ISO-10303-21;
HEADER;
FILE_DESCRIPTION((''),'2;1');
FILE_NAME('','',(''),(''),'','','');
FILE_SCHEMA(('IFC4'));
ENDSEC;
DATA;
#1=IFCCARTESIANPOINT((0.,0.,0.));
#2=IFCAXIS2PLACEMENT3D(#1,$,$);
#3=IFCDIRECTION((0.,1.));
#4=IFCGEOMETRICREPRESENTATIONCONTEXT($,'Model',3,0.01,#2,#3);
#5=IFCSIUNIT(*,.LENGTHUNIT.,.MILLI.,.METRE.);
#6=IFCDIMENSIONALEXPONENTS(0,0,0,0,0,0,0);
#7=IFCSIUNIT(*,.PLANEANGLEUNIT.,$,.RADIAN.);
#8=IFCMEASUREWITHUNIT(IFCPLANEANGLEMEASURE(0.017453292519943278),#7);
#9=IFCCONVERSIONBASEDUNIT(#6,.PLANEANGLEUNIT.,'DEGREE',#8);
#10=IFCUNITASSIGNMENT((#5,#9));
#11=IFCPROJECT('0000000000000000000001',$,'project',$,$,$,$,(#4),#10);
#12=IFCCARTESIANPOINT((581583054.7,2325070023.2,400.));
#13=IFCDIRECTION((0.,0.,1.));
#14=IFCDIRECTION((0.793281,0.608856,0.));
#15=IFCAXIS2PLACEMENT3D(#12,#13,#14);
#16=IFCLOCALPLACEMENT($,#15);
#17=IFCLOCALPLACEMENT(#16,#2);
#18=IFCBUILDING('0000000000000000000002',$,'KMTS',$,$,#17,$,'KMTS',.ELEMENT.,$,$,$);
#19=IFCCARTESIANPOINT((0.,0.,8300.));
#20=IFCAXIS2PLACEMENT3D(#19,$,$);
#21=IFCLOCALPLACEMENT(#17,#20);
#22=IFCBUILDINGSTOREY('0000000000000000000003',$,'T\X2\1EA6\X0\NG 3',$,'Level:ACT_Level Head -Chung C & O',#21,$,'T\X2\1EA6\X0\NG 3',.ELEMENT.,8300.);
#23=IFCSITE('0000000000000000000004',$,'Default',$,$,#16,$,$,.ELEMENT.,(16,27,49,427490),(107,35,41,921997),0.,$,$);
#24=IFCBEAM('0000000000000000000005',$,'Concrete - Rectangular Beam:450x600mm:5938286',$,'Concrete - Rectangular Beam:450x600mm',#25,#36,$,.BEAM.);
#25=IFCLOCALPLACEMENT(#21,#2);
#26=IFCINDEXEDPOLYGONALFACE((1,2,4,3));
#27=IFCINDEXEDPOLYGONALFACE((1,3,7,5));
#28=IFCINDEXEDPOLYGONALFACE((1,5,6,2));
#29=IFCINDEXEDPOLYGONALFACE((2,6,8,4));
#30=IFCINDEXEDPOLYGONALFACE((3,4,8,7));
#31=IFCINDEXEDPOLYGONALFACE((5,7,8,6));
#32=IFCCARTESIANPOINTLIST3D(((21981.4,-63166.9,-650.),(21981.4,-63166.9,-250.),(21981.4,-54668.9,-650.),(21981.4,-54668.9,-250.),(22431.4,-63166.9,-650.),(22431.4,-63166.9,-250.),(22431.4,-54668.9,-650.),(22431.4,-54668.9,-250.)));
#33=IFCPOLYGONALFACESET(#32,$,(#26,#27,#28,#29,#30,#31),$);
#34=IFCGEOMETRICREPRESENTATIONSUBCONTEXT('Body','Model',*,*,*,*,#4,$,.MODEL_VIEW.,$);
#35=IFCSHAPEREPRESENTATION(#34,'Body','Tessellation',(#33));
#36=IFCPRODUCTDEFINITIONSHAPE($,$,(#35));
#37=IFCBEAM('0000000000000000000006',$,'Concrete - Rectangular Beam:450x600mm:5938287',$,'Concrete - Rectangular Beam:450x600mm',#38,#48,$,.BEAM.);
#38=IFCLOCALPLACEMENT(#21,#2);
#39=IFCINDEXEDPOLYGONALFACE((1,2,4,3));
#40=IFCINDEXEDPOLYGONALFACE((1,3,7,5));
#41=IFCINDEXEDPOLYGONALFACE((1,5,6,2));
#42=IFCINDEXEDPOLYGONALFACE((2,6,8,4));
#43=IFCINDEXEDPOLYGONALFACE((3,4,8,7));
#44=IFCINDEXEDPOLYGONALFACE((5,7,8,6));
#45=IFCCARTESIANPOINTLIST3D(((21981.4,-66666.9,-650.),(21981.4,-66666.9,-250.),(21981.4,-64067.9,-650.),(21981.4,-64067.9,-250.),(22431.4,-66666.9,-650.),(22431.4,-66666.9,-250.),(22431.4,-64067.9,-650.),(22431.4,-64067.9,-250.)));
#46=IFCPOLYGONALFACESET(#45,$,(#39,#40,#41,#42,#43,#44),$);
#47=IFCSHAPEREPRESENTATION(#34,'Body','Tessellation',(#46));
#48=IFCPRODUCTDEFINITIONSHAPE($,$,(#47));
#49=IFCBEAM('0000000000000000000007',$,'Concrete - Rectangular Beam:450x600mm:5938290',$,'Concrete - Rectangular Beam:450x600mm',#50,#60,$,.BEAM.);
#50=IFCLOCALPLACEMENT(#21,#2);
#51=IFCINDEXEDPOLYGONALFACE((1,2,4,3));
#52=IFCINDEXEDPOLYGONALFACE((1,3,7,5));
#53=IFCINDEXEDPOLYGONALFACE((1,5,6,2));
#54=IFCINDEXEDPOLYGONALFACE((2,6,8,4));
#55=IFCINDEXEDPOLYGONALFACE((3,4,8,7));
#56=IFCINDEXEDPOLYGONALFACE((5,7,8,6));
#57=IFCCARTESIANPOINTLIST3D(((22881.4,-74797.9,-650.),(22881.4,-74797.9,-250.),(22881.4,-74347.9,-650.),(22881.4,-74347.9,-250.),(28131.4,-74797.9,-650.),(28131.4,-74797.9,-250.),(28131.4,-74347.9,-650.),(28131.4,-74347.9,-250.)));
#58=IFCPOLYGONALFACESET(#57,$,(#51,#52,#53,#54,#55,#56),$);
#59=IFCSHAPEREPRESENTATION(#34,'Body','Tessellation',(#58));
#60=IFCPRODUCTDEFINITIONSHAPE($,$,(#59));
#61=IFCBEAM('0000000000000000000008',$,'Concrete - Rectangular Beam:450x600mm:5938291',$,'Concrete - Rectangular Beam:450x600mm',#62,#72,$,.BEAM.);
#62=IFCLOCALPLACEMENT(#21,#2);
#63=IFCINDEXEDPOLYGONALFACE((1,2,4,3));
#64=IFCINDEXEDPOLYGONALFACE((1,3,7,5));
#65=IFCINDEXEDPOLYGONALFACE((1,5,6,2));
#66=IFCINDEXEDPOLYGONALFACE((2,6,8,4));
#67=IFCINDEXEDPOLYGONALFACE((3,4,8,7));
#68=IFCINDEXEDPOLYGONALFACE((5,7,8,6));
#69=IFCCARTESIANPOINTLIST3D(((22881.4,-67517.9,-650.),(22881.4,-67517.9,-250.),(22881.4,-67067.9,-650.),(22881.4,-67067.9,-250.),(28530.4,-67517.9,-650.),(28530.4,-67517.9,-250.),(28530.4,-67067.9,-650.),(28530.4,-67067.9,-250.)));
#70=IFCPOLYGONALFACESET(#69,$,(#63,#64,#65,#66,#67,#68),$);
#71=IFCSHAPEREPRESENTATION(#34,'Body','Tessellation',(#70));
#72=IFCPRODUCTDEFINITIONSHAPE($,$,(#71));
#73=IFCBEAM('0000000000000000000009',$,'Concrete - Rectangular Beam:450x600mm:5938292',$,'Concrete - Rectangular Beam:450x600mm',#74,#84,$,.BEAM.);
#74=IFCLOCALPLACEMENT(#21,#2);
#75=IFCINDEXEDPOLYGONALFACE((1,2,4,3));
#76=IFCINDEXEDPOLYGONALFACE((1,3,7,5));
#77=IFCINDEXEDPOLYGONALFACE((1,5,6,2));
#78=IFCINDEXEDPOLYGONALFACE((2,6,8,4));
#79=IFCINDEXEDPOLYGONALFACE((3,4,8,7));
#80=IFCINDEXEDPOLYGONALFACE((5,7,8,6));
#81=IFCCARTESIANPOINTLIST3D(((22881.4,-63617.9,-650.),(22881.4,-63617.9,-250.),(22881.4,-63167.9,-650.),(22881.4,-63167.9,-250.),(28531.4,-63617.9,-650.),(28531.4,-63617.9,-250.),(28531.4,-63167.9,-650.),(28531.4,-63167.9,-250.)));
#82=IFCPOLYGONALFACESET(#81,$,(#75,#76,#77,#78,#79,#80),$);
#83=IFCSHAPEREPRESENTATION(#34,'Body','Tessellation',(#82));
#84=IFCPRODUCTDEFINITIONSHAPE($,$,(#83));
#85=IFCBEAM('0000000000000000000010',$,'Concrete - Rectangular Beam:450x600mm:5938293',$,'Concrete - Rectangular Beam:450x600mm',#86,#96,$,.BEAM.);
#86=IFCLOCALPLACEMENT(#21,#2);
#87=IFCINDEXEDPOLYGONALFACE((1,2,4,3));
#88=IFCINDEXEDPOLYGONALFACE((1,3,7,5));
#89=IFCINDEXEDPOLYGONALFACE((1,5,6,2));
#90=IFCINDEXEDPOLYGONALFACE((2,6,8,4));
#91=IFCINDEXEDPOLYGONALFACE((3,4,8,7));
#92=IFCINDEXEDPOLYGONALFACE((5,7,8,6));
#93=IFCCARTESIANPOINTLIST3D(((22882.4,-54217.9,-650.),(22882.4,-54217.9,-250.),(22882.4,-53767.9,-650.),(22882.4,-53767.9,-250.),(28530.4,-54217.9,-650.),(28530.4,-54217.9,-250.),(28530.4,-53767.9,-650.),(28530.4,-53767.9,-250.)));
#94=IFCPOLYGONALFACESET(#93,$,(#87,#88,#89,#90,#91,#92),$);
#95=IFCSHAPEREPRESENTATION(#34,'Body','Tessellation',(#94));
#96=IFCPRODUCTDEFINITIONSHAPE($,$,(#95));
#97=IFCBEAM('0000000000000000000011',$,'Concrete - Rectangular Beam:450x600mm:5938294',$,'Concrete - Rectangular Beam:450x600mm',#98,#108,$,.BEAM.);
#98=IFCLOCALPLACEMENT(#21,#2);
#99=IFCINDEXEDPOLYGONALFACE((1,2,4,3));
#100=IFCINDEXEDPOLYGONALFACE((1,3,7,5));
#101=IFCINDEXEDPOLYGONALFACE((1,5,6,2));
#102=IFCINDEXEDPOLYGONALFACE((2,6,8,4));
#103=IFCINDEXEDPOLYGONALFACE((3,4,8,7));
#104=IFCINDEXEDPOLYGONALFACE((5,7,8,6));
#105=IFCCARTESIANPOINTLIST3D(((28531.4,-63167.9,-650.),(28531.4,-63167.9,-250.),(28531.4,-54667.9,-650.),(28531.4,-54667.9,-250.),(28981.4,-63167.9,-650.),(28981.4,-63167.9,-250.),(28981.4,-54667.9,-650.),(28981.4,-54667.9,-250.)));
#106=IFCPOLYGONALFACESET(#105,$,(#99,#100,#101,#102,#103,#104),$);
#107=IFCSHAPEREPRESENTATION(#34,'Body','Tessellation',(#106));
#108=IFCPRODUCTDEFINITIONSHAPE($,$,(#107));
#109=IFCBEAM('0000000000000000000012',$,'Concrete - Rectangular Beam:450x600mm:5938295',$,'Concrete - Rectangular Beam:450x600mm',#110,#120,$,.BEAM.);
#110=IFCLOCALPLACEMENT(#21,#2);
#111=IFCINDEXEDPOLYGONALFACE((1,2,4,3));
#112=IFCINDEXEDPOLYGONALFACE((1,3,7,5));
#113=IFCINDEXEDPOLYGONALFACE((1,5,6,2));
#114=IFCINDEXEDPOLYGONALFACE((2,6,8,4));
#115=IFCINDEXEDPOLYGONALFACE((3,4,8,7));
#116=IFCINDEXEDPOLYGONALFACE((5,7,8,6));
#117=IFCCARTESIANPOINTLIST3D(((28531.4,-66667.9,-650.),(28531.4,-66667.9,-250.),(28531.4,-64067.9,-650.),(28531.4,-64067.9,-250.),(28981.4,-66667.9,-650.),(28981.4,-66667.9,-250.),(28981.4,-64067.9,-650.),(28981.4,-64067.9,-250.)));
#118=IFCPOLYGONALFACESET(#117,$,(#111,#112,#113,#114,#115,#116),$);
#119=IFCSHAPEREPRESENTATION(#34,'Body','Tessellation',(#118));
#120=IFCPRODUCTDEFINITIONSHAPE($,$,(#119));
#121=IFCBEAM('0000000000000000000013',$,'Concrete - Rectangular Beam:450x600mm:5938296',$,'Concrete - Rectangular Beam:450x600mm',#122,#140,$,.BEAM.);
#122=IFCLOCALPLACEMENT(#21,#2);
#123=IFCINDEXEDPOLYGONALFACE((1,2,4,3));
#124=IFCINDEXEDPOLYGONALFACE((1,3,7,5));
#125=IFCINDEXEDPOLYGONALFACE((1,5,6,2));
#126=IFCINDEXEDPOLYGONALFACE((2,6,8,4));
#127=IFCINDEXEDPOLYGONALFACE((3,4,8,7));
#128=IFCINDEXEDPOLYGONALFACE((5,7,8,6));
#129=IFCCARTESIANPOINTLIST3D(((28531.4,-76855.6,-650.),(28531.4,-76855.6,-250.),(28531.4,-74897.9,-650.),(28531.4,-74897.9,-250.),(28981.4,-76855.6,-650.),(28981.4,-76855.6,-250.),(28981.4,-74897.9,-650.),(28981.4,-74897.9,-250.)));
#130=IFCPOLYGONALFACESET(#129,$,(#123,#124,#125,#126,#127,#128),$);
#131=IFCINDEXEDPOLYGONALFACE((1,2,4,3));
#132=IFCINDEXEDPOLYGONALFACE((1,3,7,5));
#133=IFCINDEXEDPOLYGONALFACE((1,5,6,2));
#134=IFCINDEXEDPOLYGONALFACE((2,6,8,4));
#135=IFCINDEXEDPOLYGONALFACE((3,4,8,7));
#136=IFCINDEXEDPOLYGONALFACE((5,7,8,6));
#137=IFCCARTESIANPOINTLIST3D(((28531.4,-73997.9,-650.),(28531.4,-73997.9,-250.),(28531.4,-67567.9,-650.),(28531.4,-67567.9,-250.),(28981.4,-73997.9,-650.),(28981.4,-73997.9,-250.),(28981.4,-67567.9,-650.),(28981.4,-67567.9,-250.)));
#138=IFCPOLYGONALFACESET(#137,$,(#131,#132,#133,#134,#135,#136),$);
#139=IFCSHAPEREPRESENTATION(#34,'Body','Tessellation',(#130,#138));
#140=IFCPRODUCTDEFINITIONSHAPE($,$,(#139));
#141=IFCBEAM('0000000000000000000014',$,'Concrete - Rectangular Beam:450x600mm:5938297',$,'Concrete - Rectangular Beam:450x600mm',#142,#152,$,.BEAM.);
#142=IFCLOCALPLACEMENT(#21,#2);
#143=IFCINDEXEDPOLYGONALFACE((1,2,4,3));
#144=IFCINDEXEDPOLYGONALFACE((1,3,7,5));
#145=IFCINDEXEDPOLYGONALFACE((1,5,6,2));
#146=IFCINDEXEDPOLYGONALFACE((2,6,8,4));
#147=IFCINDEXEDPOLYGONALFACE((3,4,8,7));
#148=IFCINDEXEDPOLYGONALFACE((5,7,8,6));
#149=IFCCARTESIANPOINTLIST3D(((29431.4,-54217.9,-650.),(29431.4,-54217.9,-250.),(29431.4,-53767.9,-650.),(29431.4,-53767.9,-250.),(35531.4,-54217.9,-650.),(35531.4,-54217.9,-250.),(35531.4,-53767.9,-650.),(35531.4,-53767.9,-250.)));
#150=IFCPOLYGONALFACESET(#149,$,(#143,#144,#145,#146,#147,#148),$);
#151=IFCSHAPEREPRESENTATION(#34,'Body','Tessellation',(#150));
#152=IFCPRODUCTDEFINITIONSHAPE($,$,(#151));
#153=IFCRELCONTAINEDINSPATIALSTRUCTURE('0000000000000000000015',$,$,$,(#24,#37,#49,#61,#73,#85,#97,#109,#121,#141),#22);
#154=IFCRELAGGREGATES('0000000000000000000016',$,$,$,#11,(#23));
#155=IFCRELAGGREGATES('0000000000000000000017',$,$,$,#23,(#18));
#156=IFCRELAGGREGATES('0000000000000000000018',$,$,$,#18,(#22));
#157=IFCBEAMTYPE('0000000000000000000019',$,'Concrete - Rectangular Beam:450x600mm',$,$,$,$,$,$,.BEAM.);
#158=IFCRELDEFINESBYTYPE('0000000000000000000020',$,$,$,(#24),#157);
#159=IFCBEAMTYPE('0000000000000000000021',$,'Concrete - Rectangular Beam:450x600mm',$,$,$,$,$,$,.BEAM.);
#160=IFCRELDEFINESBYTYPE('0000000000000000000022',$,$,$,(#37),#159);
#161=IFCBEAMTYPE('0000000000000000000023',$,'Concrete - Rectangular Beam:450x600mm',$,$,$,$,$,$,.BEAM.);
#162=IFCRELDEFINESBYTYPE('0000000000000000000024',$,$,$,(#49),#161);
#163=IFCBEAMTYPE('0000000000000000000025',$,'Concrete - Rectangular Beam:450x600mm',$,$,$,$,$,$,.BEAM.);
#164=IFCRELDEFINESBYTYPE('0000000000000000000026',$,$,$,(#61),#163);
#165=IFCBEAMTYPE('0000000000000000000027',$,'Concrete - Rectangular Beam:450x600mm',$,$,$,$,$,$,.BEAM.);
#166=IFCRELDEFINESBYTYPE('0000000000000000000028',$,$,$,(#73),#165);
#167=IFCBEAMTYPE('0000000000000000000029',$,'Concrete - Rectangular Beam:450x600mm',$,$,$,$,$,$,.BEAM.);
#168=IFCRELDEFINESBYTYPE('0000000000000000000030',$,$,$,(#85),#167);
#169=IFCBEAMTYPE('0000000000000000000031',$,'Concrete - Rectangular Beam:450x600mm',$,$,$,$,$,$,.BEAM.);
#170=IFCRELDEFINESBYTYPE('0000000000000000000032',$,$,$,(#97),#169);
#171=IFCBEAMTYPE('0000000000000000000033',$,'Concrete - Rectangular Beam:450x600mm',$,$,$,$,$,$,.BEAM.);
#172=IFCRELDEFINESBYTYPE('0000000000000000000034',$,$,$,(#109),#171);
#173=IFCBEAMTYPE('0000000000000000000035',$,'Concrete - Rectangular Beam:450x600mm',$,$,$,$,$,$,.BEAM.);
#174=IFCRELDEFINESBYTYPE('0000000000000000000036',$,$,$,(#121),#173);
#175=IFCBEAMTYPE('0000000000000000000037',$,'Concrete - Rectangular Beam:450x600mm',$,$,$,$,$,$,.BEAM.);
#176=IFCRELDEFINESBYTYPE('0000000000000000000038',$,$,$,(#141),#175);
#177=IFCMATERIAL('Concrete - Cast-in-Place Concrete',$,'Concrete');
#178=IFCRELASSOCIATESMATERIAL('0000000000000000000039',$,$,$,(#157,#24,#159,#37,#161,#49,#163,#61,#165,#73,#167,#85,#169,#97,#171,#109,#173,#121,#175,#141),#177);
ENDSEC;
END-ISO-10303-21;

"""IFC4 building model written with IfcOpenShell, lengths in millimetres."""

from ifc_helpers import new_model, entity, si_unit, converted_unit, direction, frame, origin, place, context, subcontext, project, spatial, indexed_curve, outline, extrude, source, transform, mapped, material, type_object, type_shapes, element, save


model = new_model("IFC4")

# Units and contexts
model_context = context("Model", 3, precision=0.01, world=origin(), true_north=direction((0.0, 1.0)))
body_context = subcontext(model_context, "Body", "Model", "MODEL_VIEW")
ifc_project = project(units=[si_unit("LENGTHUNIT", "METRE", prefix="MILLI"), converted_unit("PLANEANGLEUNIT", "DEGREE", entity("IfcPlaneAngleMeasure", 0.017453292519943278), si_unit("PLANEANGLEUNIT", "RADIAN"), dimensions=[0, 0, 0, 0, 0, 0, 0])], contexts=[model_context])

# Site, building, storey
site_placement = place(None, frame((581583054.7, 2325070023.2, 400.0), z_axis=(0.0, 0.0, 1.0), x_axis=(0.793281, 0.608856, 0.0)))
site = spatial("IfcSite", under=ifc_project, at=site_placement, Name="Default", CompositionType="ELEMENT", RefLatitude=(16, 27, 49, 427490), RefLongitude=(107, 35, 41, 921997), RefElevation=0.0)
building_placement = place(site_placement, origin())
building = spatial("IfcBuilding", under=site, at=building_placement, Name="KMTS", LongName="KMTS", CompositionType="ELEMENT")
storey_placement = place(building_placement, frame((0.0, 0.0, 8300.0)))
storey = spatial("IfcBuildingStorey", under=building, at=storey_placement, Name="TẦNG 3", ObjectType="Level:ACT_Level Head -Chung C & O", LongName="TẦNG 3", CompositionType="ELEMENT", Elevation=8300.0)

# Beams
ifc_material = material(Name="Concrete - Cast-in-Place Concrete", Category="Concrete")
beam_type_1 = type_object("IfcBeamType", Name="Concrete - Rectangular Beam:450x600mm", PredefinedType="BEAM", material=ifc_material)
shared_shape_1 = source(origin(), body_context, "Body", "SweptSolid", [
    extrude(outline(indexed_curve([(-225.0, -200.0), (225.0, -200.0), (225.0, 200.0), (-225.0, 200.0), (-225.0, -200.0)], self_intersect=False)), frame((22206.4, -54668.9, 7850.0), z_axis=(0.0, -1.0, 0.0), x_axis=(-1.0, 0.0, 0.0)), (0.0, 0.0, 1.0), 8498.0),
])
type_shapes(beam_type_1, [shared_shape_1])
beam_1_placement = place(storey_placement, frame((0.0, 0.0, -8300.0)))
element("IfcBeam", 1, at=beam_1_placement, inside=storey, type_object=beam_type_1, material=ifc_material, Name="Concrete - Rectangular Beam:450x600mm:5938286", ObjectType="Concrete - Rectangular Beam:450x600mm", PredefinedType="BEAM", context=body_context, shape_type="MappedRepresentation", body=[
    mapped(shared_shape_1, transform((0.0, 0.0, 0.0), scale=1.0)),
])
beam_type_2 = type_object("IfcBeamType", Name="Concrete - Rectangular Beam:450x600mm", PredefinedType="BEAM", material=ifc_material)
shared_shape_2 = source(origin(), body_context, "Body", "SweptSolid", [
    extrude(outline(indexed_curve([(-225.0, -200.0), (225.0, -200.0), (225.0, 200.0), (-225.0, 200.0), (-225.0, -200.0)], self_intersect=False)), frame((22206.4, -66666.9, 7850.0), z_axis=(0.0, 1.0, 0.0), x_axis=(-1.0, 0.0, 0.0)), (0.0, 0.0, 1.0), 2599.0),
])
type_shapes(beam_type_2, [shared_shape_2])
beam_2_placement = place(storey_placement, frame((0.0, 0.0, -8300.0)))
element("IfcBeam", 2, at=beam_2_placement, inside=storey, type_object=beam_type_2, material=ifc_material, Name="Concrete - Rectangular Beam:450x600mm:5938287", ObjectType="Concrete - Rectangular Beam:450x600mm", PredefinedType="BEAM", context=body_context, shape_type="MappedRepresentation", body=[
    mapped(shared_shape_2, transform((0.0, 0.0, 0.0), scale=1.0)),
])
beam_type_3 = type_object("IfcBeamType", Name="Concrete - Rectangular Beam:450x600mm", PredefinedType="BEAM", material=ifc_material)
shared_shape_3 = source(origin(), body_context, "Body", "SweptSolid", [
    extrude(outline(indexed_curve([(-200.0, -225.0), (200.0, -225.0), (200.0, 225.0), (-200.0, 225.0), (-200.0, -225.0)], self_intersect=False)), frame((22881.4, -74572.9, 7850.0), z_axis=(1.0, 0.0, 0.0), x_axis=(0.0, 0.0, -1.0)), (0.0, 0.0, 1.0), 5250.0),
])
type_shapes(beam_type_3, [shared_shape_3])
beam_3_placement = place(storey_placement, frame((0.0, 0.0, -8300.0)))
element("IfcBeam", 3, at=beam_3_placement, inside=storey, type_object=beam_type_3, material=ifc_material, Name="Concrete - Rectangular Beam:450x600mm:5938290", ObjectType="Concrete - Rectangular Beam:450x600mm", PredefinedType="BEAM", context=body_context, shape_type="MappedRepresentation", body=[
    mapped(shared_shape_3, transform((0.0, 0.0, 0.0), scale=1.0)),
])
beam_type_4 = type_object("IfcBeamType", Name="Concrete - Rectangular Beam:450x600mm", PredefinedType="BEAM", material=ifc_material)
shared_shape_4 = source(origin(), body_context, "Body", "SweptSolid", [
    extrude(outline(indexed_curve([(-200.0, -225.0), (200.0, -225.0), (200.0, 225.0), (-200.0, 225.0), (-200.0, -225.0)], self_intersect=False)), frame((22881.4, -67292.9, 7850.0), z_axis=(1.0, 0.0, 0.0), x_axis=(0.0, 0.0, -1.0)), (0.0, 0.0, 1.0), 5649.0),
])
type_shapes(beam_type_4, [shared_shape_4])
beam_4_placement = place(storey_placement, frame((0.0, 0.0, -8300.0)))
element("IfcBeam", 4, at=beam_4_placement, inside=storey, type_object=beam_type_4, material=ifc_material, Name="Concrete - Rectangular Beam:450x600mm:5938291", ObjectType="Concrete - Rectangular Beam:450x600mm", PredefinedType="BEAM", context=body_context, shape_type="MappedRepresentation", body=[
    mapped(shared_shape_4, transform((0.0, 0.0, 0.0), scale=1.0)),
])
beam_type_5 = type_object("IfcBeamType", Name="Concrete - Rectangular Beam:450x600mm", PredefinedType="BEAM", material=ifc_material)
shared_shape_5 = source(origin(), body_context, "Body", "SweptSolid", [
    extrude(outline(indexed_curve([(-200.0, -225.0), (200.0, -225.0), (200.0, 225.0), (-200.0, 225.0), (-200.0, -225.0)], self_intersect=False)), frame((22881.4, -63392.9, 7850.0), z_axis=(1.0, 0.0, 0.0), x_axis=(0.0, 0.0, -1.0)), (0.0, 0.0, 1.0), 5650.0),
])
type_shapes(beam_type_5, [shared_shape_5])
beam_5_placement = place(storey_placement, frame((0.0, 0.0, -8300.0)))
element("IfcBeam", 5, at=beam_5_placement, inside=storey, type_object=beam_type_5, material=ifc_material, Name="Concrete - Rectangular Beam:450x600mm:5938292", ObjectType="Concrete - Rectangular Beam:450x600mm", PredefinedType="BEAM", context=body_context, shape_type="MappedRepresentation", body=[
    mapped(shared_shape_5, transform((0.0, 0.0, 0.0), scale=1.0)),
])
beam_type_6 = type_object("IfcBeamType", Name="Concrete - Rectangular Beam:450x600mm", PredefinedType="BEAM", material=ifc_material)
shared_shape_6 = source(origin(), body_context, "Body", "SweptSolid", [
    extrude(outline(indexed_curve([(-200.0, -225.0), (200.0, -225.0), (200.0, 225.0), (-200.0, 225.0), (-200.0, -225.0)], self_intersect=False)), frame((28530.4, -53992.9, 7850.0), z_axis=(-1.0, 0.0, 0.0), x_axis=(0.0, 0.0, -1.0)), (0.0, 0.0, 1.0), 5648.0),
])
type_shapes(beam_type_6, [shared_shape_6])
beam_6_placement = place(storey_placement, frame((0.0, 0.0, -8300.0)))
element("IfcBeam", 6, at=beam_6_placement, inside=storey, type_object=beam_type_6, material=ifc_material, Name="Concrete - Rectangular Beam:450x600mm:5938293", ObjectType="Concrete - Rectangular Beam:450x600mm", PredefinedType="BEAM", context=body_context, shape_type="MappedRepresentation", body=[
    mapped(shared_shape_6, transform((0.0, 0.0, 0.0), scale=1.0)),
])
beam_type_7 = type_object("IfcBeamType", Name="Concrete - Rectangular Beam:450x600mm", PredefinedType="BEAM", material=ifc_material)
shared_shape_7 = source(origin(), body_context, "Body", "SweptSolid", [
    extrude(outline(indexed_curve([(-225.0, -200.0), (225.0, -200.0), (225.0, 200.0), (-225.0, 200.0), (-225.0, -200.0)], self_intersect=False)), frame((28756.4, -63167.9, 7850.0), z_axis=(0.0, 1.0, 0.0), x_axis=(-1.0, 0.0, 0.0)), (0.0, 0.0, 1.0), 8500.0),
])
type_shapes(beam_type_7, [shared_shape_7])
beam_7_placement = place(storey_placement, frame((0.0, 0.0, -8300.0)))
element("IfcBeam", 7, at=beam_7_placement, inside=storey, type_object=beam_type_7, material=ifc_material, Name="Concrete - Rectangular Beam:450x600mm:5938294", ObjectType="Concrete - Rectangular Beam:450x600mm", PredefinedType="BEAM", context=body_context, shape_type="MappedRepresentation", body=[
    mapped(shared_shape_7, transform((0.0, 0.0, 0.0), scale=1.0)),
])
beam_type_8 = type_object("IfcBeamType", Name="Concrete - Rectangular Beam:450x600mm", PredefinedType="BEAM", material=ifc_material)
shared_shape_8 = source(origin(), body_context, "Body", "SweptSolid", [
    extrude(outline(indexed_curve([(-225.0, -200.0), (225.0, -200.0), (225.0, 200.0), (-225.0, 200.0), (-225.0, -200.0)], self_intersect=False)), frame((28756.4, -66667.9, 7850.0), z_axis=(0.0, 1.0, 0.0), x_axis=(-1.0, 0.0, 0.0)), (0.0, 0.0, 1.0), 2600.0),
])
type_shapes(beam_type_8, [shared_shape_8])
beam_8_placement = place(storey_placement, frame((0.0, 0.0, -8300.0)))
element("IfcBeam", 8, at=beam_8_placement, inside=storey, type_object=beam_type_8, material=ifc_material, Name="Concrete - Rectangular Beam:450x600mm:5938295", ObjectType="Concrete - Rectangular Beam:450x600mm", PredefinedType="BEAM", context=body_context, shape_type="MappedRepresentation", body=[
    mapped(shared_shape_8, transform((0.0, 0.0, 0.0), scale=1.0)),
])
beam_type_9 = type_object("IfcBeamType", Name="Concrete - Rectangular Beam:450x600mm", PredefinedType="BEAM", material=ifc_material)
shared_shape_9 = source(origin(), body_context, "Body", "SweptSolid", [
    extrude(outline(indexed_curve([(-225.0, -200.0), (225.0, -200.0), (225.0, 200.0), (-225.0, 200.0), (-225.0, -200.0)], self_intersect=False)), frame((28756.4, -76855.6, 7850.0), z_axis=(0.0, 1.0, 0.0), x_axis=(-1.0, 0.0, 0.0)), (0.0, 0.0, 1.0), 1957.7),
    extrude(outline(indexed_curve([(-225.0, -200.0), (225.0, -200.0), (225.0, 200.0), (-225.0, 200.0), (-225.0, -200.0)], self_intersect=False)), frame((28756.4, -73997.9, 7850.0), z_axis=(0.0, 1.0, 0.0), x_axis=(-1.0, 0.0, 0.0)), (0.0, 0.0, 1.0), 6430.0),
])
type_shapes(beam_type_9, [shared_shape_9])
beam_9_placement = place(storey_placement, frame((0.0, 0.0, -8300.0)))
element("IfcBeam", 9, at=beam_9_placement, inside=storey, type_object=beam_type_9, material=ifc_material, Name="Concrete - Rectangular Beam:450x600mm:5938296", ObjectType="Concrete - Rectangular Beam:450x600mm", PredefinedType="BEAM", context=body_context, shape_type="MappedRepresentation", body=[
    mapped(shared_shape_9, transform((0.0, 0.0, 0.0), scale=1.0)),
])
beam_type_10 = type_object("IfcBeamType", Name="Concrete - Rectangular Beam:450x600mm", PredefinedType="BEAM", material=ifc_material)
shared_shape_10 = source(origin(), body_context, "Body", "SweptSolid", [
    extrude(outline(indexed_curve([(-200.0, -225.0), (200.0, -225.0), (200.0, 225.0), (-200.0, 225.0), (-200.0, -225.0)], self_intersect=False)), frame((29431.4, -53992.9, 7850.0), z_axis=(1.0, 0.0, 0.0), x_axis=(0.0, 0.0, -1.0)), (0.0, 0.0, 1.0), 6100.0),
])
type_shapes(beam_type_10, [shared_shape_10])
beam_10_placement = place(storey_placement, frame((0.0, 0.0, -8300.0)))
element("IfcBeam", 10, at=beam_10_placement, inside=storey, type_object=beam_type_10, material=ifc_material, Name="Concrete - Rectangular Beam:450x600mm:5938297", ObjectType="Concrete - Rectangular Beam:450x600mm", PredefinedType="BEAM", context=body_context, shape_type="MappedRepresentation", body=[
    mapped(shared_shape_10, transform((0.0, 0.0, 0.0), scale=1.0)),
])

save(model, "model.ifc")
